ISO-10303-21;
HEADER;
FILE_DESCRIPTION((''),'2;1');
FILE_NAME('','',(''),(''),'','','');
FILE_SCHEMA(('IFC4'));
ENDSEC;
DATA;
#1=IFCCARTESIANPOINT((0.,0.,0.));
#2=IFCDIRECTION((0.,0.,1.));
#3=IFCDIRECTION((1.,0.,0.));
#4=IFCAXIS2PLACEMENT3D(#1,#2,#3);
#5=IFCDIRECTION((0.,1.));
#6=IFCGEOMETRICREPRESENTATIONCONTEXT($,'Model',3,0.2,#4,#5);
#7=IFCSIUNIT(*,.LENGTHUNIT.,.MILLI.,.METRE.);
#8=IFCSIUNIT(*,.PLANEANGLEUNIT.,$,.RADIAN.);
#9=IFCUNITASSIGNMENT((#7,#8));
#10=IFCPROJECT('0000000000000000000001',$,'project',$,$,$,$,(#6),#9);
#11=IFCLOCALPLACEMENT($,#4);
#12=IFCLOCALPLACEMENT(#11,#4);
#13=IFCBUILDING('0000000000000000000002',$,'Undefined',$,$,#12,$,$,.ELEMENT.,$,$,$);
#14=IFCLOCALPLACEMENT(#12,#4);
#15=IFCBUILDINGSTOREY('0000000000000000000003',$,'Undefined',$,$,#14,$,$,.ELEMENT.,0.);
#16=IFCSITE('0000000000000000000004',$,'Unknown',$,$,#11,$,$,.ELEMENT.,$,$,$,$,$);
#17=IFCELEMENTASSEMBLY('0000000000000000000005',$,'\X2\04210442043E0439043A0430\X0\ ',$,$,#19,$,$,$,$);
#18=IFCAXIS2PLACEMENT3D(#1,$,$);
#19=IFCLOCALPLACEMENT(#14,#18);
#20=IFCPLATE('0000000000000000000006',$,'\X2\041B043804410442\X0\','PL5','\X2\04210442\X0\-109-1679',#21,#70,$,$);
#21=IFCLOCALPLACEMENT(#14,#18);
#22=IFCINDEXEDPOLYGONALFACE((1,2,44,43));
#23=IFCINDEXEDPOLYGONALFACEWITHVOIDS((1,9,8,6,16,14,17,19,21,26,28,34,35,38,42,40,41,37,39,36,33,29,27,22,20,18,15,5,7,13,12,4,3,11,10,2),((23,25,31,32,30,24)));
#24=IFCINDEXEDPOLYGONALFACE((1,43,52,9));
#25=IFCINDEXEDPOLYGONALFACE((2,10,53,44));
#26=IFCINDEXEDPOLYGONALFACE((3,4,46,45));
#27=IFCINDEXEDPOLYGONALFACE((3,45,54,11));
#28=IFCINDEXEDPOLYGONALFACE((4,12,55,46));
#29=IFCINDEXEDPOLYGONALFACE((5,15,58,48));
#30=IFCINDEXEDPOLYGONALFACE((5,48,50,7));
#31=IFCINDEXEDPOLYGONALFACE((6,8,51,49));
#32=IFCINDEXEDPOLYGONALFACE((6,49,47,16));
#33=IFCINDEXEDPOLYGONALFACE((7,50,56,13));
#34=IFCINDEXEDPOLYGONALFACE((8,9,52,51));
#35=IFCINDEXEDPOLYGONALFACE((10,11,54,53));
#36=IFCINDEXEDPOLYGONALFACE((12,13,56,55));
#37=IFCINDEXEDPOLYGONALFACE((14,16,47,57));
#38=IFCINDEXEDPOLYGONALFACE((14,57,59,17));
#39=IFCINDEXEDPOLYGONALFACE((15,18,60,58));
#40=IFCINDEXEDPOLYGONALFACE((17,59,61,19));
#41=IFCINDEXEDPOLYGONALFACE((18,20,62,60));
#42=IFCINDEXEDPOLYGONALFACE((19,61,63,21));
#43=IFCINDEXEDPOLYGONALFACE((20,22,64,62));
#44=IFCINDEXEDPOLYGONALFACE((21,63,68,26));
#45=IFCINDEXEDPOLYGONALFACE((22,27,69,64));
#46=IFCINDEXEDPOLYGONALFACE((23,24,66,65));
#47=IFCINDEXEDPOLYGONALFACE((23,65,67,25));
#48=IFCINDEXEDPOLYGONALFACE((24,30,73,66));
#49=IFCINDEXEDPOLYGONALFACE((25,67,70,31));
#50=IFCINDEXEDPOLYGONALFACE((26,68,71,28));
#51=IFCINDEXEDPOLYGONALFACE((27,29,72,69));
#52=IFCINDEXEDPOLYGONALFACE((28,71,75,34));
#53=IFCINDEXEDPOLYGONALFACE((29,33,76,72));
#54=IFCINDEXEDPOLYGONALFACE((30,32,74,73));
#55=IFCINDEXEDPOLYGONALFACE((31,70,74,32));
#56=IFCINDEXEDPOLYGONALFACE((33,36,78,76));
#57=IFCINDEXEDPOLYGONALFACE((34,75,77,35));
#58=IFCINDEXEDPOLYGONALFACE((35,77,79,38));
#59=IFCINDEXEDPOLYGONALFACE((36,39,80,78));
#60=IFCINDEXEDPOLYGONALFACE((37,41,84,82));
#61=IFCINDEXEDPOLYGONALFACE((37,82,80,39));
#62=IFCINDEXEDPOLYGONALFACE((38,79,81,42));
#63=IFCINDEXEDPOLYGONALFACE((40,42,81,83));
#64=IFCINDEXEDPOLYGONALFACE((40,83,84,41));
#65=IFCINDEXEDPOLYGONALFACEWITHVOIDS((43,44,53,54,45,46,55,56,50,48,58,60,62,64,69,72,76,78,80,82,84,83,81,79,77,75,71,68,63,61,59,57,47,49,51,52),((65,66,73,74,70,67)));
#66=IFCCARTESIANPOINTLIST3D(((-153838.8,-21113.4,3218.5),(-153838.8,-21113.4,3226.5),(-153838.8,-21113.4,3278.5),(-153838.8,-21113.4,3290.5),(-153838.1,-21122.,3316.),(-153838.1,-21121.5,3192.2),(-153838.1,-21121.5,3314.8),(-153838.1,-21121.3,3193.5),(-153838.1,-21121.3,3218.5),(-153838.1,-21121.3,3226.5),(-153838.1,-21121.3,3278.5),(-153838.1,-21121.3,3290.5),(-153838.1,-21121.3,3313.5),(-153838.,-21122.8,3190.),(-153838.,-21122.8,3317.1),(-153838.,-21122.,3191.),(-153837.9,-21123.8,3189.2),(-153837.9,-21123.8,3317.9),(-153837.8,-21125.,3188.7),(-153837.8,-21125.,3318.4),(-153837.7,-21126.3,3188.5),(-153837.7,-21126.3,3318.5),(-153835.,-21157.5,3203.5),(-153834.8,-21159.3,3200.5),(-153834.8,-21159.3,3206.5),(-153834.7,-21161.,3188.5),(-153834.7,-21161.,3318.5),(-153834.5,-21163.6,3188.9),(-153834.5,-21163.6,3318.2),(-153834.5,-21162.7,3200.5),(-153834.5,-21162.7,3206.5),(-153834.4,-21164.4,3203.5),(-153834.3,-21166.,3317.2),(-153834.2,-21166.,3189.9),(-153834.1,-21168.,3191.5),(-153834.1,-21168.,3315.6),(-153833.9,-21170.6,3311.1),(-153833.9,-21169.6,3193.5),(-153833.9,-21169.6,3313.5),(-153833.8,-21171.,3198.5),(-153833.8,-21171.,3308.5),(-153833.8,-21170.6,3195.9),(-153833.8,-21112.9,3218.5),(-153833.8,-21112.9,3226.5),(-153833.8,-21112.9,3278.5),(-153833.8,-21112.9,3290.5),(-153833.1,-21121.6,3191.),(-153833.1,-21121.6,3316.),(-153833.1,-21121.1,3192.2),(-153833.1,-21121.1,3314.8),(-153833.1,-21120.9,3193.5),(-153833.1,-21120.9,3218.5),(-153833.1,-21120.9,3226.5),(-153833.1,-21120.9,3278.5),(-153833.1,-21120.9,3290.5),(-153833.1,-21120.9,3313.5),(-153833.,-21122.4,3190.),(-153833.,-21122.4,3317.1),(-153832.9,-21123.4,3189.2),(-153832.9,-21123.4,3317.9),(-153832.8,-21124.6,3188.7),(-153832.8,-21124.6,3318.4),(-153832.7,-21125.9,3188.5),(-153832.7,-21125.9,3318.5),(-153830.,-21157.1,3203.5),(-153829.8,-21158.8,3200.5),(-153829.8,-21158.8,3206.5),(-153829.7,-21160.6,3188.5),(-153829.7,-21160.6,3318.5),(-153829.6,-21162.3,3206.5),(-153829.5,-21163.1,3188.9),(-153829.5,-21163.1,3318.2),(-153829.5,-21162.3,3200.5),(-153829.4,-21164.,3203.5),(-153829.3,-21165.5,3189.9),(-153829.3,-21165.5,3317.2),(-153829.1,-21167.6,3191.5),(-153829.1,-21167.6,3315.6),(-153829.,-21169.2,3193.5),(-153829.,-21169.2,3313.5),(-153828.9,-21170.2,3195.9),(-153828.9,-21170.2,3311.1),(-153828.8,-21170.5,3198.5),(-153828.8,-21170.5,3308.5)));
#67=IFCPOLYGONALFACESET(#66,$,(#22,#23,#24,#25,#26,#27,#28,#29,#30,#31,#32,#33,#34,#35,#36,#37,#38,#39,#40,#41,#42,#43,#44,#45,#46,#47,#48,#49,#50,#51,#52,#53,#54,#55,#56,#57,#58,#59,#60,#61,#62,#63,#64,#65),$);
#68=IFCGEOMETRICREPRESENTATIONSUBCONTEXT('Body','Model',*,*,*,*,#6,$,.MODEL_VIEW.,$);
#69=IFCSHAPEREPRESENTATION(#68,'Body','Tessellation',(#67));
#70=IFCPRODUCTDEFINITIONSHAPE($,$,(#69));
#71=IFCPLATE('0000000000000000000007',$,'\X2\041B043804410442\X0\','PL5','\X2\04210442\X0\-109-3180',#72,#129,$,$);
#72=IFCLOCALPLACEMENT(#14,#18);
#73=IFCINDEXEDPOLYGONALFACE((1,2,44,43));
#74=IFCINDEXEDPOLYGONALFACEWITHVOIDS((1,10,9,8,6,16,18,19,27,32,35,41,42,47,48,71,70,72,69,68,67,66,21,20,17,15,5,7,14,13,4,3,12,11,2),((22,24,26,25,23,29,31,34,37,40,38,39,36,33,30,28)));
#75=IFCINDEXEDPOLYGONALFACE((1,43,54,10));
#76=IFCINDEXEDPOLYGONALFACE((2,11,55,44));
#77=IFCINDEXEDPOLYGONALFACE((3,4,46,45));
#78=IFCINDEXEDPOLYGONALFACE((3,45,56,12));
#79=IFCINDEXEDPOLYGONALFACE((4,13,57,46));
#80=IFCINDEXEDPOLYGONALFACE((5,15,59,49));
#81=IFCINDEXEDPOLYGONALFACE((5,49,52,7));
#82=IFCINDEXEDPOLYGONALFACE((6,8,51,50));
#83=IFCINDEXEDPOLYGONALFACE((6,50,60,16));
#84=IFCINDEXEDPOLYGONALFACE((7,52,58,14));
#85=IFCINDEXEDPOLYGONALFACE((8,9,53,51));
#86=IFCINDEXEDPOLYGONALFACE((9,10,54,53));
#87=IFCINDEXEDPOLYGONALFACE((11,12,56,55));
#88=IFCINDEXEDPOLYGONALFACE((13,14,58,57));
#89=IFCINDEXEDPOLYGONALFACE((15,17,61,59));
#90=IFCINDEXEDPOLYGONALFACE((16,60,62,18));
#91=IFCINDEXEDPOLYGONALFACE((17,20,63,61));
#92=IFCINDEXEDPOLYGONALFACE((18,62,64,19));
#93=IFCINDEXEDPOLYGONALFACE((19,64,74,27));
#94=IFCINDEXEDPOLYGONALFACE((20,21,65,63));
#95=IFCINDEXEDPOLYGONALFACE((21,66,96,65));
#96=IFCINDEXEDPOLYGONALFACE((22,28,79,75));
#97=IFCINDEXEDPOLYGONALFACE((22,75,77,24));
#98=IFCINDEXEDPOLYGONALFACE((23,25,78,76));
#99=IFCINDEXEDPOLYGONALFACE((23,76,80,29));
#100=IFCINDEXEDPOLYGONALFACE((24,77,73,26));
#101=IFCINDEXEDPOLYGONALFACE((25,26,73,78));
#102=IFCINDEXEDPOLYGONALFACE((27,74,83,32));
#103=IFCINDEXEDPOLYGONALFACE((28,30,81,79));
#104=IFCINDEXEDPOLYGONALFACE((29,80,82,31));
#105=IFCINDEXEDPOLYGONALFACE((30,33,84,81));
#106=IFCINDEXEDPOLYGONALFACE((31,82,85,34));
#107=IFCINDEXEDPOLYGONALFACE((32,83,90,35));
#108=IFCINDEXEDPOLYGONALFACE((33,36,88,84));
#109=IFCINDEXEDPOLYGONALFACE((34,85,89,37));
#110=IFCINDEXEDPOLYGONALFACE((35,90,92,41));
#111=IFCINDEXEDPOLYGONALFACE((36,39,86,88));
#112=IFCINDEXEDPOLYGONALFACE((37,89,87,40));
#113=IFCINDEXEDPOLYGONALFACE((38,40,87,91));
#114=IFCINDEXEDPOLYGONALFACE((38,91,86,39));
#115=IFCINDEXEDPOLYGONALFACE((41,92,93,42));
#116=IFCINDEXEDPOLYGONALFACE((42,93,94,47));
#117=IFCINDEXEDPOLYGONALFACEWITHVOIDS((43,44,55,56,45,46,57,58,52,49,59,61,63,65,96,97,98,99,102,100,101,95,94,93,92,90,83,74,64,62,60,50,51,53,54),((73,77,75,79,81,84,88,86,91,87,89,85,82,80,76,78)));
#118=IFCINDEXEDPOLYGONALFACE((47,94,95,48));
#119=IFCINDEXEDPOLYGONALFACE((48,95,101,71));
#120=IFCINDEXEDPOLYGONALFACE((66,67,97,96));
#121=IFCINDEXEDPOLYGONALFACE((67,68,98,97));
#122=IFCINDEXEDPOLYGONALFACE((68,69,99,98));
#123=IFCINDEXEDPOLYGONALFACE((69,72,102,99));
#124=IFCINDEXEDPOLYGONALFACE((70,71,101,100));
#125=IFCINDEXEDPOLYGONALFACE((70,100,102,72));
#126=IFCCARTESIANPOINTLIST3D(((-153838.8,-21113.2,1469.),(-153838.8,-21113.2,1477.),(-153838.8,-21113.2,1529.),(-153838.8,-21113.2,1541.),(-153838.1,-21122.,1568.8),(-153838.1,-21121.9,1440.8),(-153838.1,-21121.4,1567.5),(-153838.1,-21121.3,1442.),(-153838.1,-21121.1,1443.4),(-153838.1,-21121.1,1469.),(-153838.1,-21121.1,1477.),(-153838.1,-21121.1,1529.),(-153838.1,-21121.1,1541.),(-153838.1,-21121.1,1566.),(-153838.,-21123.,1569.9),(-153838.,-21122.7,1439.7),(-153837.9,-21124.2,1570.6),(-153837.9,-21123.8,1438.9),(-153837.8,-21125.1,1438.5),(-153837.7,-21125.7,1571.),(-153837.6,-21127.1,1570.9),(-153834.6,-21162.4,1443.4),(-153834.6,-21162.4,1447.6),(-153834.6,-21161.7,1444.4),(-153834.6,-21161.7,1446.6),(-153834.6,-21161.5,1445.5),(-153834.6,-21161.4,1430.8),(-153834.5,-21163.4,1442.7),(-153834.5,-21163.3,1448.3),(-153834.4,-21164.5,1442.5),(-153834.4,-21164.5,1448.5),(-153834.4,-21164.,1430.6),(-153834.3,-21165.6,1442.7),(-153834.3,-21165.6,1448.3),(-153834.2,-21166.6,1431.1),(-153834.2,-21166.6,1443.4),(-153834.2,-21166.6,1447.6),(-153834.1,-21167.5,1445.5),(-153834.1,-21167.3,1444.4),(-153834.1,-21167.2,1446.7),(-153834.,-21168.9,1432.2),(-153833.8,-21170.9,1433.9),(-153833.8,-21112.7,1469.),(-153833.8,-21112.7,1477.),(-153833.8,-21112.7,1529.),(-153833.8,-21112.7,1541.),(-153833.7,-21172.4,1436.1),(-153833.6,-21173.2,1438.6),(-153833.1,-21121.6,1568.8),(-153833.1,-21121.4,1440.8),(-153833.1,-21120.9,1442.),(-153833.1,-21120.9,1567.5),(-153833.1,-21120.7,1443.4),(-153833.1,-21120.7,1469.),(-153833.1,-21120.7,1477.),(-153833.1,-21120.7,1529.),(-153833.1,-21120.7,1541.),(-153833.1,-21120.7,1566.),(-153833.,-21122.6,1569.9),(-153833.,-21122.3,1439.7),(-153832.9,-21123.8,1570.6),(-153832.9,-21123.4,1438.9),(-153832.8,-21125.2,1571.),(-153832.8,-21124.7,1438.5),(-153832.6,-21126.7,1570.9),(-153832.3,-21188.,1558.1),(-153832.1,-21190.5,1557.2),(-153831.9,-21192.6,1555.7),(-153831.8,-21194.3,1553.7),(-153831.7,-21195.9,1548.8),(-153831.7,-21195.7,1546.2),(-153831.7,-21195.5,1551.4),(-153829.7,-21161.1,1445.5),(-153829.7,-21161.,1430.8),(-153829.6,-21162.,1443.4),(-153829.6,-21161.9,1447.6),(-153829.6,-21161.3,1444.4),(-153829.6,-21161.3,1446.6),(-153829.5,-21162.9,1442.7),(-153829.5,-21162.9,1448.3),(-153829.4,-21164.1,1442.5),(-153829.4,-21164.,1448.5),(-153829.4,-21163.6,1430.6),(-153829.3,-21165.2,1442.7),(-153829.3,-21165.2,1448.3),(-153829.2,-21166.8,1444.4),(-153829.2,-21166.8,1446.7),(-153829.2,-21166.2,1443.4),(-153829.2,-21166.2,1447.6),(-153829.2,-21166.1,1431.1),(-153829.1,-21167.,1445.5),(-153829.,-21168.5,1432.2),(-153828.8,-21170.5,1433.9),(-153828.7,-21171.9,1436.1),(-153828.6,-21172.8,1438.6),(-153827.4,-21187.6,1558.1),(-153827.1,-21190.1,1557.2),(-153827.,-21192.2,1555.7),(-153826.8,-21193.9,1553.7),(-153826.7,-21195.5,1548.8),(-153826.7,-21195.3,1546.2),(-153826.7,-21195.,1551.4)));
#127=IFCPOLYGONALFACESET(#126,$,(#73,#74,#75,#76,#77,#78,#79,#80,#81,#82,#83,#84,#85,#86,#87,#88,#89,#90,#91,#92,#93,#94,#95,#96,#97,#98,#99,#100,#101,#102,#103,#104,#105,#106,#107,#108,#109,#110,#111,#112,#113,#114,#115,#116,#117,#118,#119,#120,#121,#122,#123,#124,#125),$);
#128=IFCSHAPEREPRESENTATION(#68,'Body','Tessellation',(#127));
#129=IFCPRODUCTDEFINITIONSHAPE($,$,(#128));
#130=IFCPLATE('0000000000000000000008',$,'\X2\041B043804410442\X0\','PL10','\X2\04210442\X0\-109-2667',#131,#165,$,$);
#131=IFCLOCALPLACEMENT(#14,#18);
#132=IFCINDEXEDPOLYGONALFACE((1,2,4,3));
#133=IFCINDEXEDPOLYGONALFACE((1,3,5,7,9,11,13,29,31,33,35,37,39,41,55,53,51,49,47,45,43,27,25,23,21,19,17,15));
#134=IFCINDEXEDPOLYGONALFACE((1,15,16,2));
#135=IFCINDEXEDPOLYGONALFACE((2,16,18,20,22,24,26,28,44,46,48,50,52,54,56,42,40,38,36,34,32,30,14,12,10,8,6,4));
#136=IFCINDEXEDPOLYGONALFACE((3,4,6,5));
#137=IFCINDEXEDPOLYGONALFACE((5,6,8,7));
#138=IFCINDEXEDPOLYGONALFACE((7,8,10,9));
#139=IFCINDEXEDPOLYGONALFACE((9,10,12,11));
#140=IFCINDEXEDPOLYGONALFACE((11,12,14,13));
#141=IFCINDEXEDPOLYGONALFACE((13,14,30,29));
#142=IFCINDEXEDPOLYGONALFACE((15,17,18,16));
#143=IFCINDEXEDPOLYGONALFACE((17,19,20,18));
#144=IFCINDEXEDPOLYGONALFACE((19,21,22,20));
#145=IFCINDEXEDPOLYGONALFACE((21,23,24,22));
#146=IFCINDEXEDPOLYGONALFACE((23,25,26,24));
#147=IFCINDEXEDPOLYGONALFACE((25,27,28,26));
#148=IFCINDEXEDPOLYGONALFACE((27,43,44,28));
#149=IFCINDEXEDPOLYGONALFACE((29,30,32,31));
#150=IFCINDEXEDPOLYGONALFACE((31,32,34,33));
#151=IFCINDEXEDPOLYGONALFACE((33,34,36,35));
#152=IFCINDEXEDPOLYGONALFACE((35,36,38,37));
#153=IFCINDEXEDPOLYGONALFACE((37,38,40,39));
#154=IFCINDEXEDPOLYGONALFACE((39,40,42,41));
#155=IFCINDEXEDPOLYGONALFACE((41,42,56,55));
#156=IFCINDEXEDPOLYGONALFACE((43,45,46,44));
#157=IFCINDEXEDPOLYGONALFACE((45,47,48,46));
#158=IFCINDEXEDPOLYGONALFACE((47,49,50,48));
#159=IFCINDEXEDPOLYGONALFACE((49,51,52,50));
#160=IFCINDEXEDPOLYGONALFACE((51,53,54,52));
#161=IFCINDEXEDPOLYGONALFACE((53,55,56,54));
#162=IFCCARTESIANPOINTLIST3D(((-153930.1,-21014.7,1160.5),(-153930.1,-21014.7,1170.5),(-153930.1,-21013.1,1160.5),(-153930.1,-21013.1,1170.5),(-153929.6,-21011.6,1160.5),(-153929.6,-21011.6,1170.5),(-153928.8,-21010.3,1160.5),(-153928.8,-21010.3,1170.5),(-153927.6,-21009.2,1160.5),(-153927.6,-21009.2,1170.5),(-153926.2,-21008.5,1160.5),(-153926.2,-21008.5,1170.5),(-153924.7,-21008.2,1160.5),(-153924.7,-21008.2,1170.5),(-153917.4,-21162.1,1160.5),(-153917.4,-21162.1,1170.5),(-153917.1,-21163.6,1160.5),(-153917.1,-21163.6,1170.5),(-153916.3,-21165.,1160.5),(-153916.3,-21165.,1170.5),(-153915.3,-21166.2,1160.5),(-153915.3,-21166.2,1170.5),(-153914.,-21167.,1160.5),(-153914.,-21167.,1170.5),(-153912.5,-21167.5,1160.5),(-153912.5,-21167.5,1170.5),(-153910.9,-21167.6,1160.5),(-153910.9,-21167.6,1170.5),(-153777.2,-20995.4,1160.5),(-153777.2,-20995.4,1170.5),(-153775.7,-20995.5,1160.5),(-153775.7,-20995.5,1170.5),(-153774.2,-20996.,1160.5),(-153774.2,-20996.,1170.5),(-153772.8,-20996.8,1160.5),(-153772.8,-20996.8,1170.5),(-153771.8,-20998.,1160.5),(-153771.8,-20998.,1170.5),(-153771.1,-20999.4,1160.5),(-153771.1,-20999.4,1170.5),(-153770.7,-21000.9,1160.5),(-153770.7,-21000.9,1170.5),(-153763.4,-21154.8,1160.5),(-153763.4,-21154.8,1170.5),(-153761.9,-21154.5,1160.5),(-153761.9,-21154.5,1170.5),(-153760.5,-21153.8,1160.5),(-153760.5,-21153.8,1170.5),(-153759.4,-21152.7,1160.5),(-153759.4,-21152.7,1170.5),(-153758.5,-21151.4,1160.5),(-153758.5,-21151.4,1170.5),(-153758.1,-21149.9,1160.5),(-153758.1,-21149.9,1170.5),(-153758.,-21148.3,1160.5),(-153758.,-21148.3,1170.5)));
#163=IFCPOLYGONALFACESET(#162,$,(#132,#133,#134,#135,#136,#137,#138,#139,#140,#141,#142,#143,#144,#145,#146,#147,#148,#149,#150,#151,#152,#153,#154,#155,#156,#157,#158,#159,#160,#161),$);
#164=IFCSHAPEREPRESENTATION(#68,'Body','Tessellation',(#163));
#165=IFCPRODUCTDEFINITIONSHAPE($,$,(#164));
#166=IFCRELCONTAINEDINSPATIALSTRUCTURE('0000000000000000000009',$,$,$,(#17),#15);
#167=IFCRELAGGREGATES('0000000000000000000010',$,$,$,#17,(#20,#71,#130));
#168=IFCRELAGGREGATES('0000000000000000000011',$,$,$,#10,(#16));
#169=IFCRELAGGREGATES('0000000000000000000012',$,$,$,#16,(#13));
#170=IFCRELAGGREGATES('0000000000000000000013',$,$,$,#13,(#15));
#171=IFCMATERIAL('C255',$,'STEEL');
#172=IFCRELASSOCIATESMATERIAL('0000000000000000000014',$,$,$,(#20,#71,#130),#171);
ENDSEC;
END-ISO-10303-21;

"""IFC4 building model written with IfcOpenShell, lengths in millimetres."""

from ifc_helpers import new_model, si_unit, direction, frame, origin_with_axes, place, context, subcontext, project, spatial, line, arc, indexed_curve, outline, extrude, material, element, aggregate, save


model = new_model("IFC4")

# Units and contexts
model_context = context("Model", 3, precision=0.2, world=origin_with_axes(), true_north=direction((0.0, 1.0)))
body_context = subcontext(model_context, "Body", "Model", "MODEL_VIEW")
ifc_project = project(units=[si_unit("LENGTHUNIT", "METRE", prefix="MILLI"), si_unit("PLANEANGLEUNIT", "RADIAN")], contexts=[model_context])

# Site, building, storey
site_placement = place(None, origin_with_axes())
site = spatial("IfcSite", under=ifc_project, at=site_placement, Name="Unknown", CompositionType="ELEMENT")
building_placement = place(site_placement, origin_with_axes())
building = spatial("IfcBuilding", under=site, at=building_placement, Name="Undefined", CompositionType="ELEMENT")
storey_placement = place(building_placement, origin_with_axes())
storey = spatial("IfcBuildingStorey", under=building, at=storey_placement, Name="Undefined", CompositionType="ELEMENT", Elevation=0.0)

# Element assembly, plates, voiding features
assembly_1_placement = place(storey_placement, frame((-153844.1, -21081.5, 1298.5), z_axis=(-0.086114, 0.996285, 0.0), x_axis=(0.0, 0.0, 1.0)))
assembly_1 = element("IfcElementAssembly", 1, at=assembly_1_placement, inside=storey, Name="Стойка ")
ifc_material_1 = material(Name="C255", Category="STEEL")
plate_1_placement = place(assembly_1_placement, frame((1890.0, 5.0, -90.0), z_axis=(-0.000024, -1.0, 0.0), x_axis=(1.0, -0.000024, 0.0)))
plate_1 = element("IfcPlate", 2, at=plate_1_placement, material=ifc_material_1, Name="Лист", Description="PL5", ObjectType="Ст-109-1679", context=body_context, shape_type="SolidModel", body=[
    extrude(outline(indexed_curve([(0.0, 10.0), (2.9, 2.9), (10.0, 0.0), (120.0, 0.0), (127.1, 2.9), (130.0, 10.0), (130.0, 44.8), (128.5, 48.3), (125.0, 49.8), (102.0, 49.8), (102.0, 57.8), (90.0, 57.8), (90.0, 49.8), (38.0, 49.8), (38.0, 57.8), (30.0, 57.8), (30.0, 49.8), (5.0, 49.8), (1.5, 48.3), (0.0, 44.8)], segments=[arc(1, 2, 3), line(3, 4), arc(4, 5, 6), line(6, 7), arc(7, 8, 9), line(9, 10, 11, 12, 13, 14, 15, 16, 17, 18), arc(18, 19, 20), line(20, 1)])), frame((0.0, 0.0, 2.5), z_axis=(0.0, 0.0, 1.0), x_axis=(1.0, 0.0, 0.0)), (0.0, 0.0, -1.0), 5.0),
])
voiding_feature_1_placement = place(plate_1_placement, frame((15.0, 10.0, 10.0), z_axis=(0.003022, -0.999995, 0.0), x_axis=(0.0, 0.0, -1.0)))
element("IfcVoidingFeature", 3, at=voiding_feature_1_placement, cuts=plate_1, Name="Балка", ObjectType="(?)", PredefinedType="HOLE", context=body_context, shape_type="SolidModel", body=[
    extrude(outline(indexed_curve([(1.7, -3.0), (3.5, 0.0), (1.7, 3.0), (-1.7, 3.0), (-3.5, 0.0), (-1.7, -3.0)], segments=[line(1, 2, 3, 4, 5, 6, 1)])), frame((0.0, 0.0, 0.0), z_axis=(-1.0, 0.0, 0.0), x_axis=(0.0, 0.0, 1.0)), (0.0, 0.0, -1.0), 20.0),
])
plate_2_placement = place(assembly_1_placement, frame((130.2, 5.0, -90.2), z_axis=(0.000024, -1.0, -0.000005), x_axis=(0.978653, 0.000024, -0.205517)))
plate_2 = element("IfcPlate", 4, at=plate_2_placement, material=ifc_material_1, Name="Лист", Description="PL5", ObjectType="Ст-109-3180", context=body_context, shape_type="SolidModel", body=[
    extrude(outline(indexed_curve([(0.0, 10.0), (2.9, 2.9), (10.0, 0.0), (120.0, 0.0), (127.1, 2.9), (130.0, 10.0), (130.0, 72.5), (128.2, 76.3), (124.0, 77.3), (99.5, 72.2), (97.9, 80.0), (86.2, 77.6), (87.8, 69.7), (36.9, 59.1), (35.3, 66.9), (27.4, 65.2), (29.1, 57.4), (4.0, 52.1), (1.1, 50.4), (0.0, 47.2)], segments=[arc(1, 2, 3), line(3, 4), arc(4, 5, 6), line(6, 7), arc(7, 8, 9), line(9, 10, 11, 12, 13, 14, 15, 16, 17, 18), arc(18, 19, 20), line(20, 1)])), frame((0.0, 0.0, 2.5), z_axis=(0.0, 0.0, 1.0), x_axis=(1.0, 0.0, 0.0)), (0.0, 0.0, -1.0), 5.0),
])
voiding_feature_2_placement = place(plate_2_placement, frame((15.0, 10.0, 10.0), z_axis=(0.208475, -0.978028, 0.0), x_axis=(0.0, 0.0, -1.0)))
element("IfcVoidingFeature", 5, at=voiding_feature_2_placement, cuts=plate_2, Name="Балка", ObjectType="(?)", PredefinedType="HOLE", context=body_context, shape_type="SolidModel", body=[
    extrude(outline(indexed_curve([(3.0, 0.0), (2.8, 1.1), (2.1, 2.1), (1.1, 2.8), (0.0, 3.0), (-1.1, 2.8), (-2.1, 2.1), (-2.8, 1.1), (-3.0, 0.0), (-2.8, -1.1), (-2.1, -2.1), (-1.1, -2.8), (0.0, -3.0), (1.1, -2.8), (2.1, -2.1), (2.8, -1.1)], segments=[line(1, 2, 3, 4, 5, 6, 7, 8, 9, 10, 11, 12, 13, 14, 15, 16, 1)])), frame((0.0, 0.0, 0.0), z_axis=(-1.0, 0.0, 0.0), x_axis=(0.0, 0.0, 1.0)), (0.0, 0.0, -1.0), 20.0),
])
plate_3_placement = place(assembly_1_placement, frame((-133.0, 80.0, -80.0), z_axis=(1.0, 0.0, 0.0), x_axis=(0.0, 0.0, 1.0)))
plate_3 = element("IfcPlate", 6, at=plate_3_placement, material=ifc_material_1, Name="Лист", Description="PL10", ObjectType="Ст-109-2667", context=body_context, shape_type="SolidModel", body=[
    extrude(outline(indexed_curve([(0.0, 6.0), (1.8, 1.8), (6.0, 0.0), (154.0, 0.0), (158.2, 1.8), (160.0, 6.0), (160.0, 154.0), (158.2, 158.2), (154.0, 160.0), (6.0, 160.0), (1.8, 158.2), (0.0, 154.0)], segments=[arc(1, 2, 3), line(3, 4), arc(4, 5, 6), line(6, 7), arc(7, 8, 9), line(9, 10), arc(10, 11, 12), line(12, 1)])), frame((0.0, 0.0, 5.0), z_axis=(0.0, 0.0, 1.0), x_axis=(1.0, 0.0, 0.0)), (0.0, 0.0, -1.0), 10.0),
])

aggregate(assembly_1, [plate_1, plate_2, plate_3])

save(model, "model.ifc")
